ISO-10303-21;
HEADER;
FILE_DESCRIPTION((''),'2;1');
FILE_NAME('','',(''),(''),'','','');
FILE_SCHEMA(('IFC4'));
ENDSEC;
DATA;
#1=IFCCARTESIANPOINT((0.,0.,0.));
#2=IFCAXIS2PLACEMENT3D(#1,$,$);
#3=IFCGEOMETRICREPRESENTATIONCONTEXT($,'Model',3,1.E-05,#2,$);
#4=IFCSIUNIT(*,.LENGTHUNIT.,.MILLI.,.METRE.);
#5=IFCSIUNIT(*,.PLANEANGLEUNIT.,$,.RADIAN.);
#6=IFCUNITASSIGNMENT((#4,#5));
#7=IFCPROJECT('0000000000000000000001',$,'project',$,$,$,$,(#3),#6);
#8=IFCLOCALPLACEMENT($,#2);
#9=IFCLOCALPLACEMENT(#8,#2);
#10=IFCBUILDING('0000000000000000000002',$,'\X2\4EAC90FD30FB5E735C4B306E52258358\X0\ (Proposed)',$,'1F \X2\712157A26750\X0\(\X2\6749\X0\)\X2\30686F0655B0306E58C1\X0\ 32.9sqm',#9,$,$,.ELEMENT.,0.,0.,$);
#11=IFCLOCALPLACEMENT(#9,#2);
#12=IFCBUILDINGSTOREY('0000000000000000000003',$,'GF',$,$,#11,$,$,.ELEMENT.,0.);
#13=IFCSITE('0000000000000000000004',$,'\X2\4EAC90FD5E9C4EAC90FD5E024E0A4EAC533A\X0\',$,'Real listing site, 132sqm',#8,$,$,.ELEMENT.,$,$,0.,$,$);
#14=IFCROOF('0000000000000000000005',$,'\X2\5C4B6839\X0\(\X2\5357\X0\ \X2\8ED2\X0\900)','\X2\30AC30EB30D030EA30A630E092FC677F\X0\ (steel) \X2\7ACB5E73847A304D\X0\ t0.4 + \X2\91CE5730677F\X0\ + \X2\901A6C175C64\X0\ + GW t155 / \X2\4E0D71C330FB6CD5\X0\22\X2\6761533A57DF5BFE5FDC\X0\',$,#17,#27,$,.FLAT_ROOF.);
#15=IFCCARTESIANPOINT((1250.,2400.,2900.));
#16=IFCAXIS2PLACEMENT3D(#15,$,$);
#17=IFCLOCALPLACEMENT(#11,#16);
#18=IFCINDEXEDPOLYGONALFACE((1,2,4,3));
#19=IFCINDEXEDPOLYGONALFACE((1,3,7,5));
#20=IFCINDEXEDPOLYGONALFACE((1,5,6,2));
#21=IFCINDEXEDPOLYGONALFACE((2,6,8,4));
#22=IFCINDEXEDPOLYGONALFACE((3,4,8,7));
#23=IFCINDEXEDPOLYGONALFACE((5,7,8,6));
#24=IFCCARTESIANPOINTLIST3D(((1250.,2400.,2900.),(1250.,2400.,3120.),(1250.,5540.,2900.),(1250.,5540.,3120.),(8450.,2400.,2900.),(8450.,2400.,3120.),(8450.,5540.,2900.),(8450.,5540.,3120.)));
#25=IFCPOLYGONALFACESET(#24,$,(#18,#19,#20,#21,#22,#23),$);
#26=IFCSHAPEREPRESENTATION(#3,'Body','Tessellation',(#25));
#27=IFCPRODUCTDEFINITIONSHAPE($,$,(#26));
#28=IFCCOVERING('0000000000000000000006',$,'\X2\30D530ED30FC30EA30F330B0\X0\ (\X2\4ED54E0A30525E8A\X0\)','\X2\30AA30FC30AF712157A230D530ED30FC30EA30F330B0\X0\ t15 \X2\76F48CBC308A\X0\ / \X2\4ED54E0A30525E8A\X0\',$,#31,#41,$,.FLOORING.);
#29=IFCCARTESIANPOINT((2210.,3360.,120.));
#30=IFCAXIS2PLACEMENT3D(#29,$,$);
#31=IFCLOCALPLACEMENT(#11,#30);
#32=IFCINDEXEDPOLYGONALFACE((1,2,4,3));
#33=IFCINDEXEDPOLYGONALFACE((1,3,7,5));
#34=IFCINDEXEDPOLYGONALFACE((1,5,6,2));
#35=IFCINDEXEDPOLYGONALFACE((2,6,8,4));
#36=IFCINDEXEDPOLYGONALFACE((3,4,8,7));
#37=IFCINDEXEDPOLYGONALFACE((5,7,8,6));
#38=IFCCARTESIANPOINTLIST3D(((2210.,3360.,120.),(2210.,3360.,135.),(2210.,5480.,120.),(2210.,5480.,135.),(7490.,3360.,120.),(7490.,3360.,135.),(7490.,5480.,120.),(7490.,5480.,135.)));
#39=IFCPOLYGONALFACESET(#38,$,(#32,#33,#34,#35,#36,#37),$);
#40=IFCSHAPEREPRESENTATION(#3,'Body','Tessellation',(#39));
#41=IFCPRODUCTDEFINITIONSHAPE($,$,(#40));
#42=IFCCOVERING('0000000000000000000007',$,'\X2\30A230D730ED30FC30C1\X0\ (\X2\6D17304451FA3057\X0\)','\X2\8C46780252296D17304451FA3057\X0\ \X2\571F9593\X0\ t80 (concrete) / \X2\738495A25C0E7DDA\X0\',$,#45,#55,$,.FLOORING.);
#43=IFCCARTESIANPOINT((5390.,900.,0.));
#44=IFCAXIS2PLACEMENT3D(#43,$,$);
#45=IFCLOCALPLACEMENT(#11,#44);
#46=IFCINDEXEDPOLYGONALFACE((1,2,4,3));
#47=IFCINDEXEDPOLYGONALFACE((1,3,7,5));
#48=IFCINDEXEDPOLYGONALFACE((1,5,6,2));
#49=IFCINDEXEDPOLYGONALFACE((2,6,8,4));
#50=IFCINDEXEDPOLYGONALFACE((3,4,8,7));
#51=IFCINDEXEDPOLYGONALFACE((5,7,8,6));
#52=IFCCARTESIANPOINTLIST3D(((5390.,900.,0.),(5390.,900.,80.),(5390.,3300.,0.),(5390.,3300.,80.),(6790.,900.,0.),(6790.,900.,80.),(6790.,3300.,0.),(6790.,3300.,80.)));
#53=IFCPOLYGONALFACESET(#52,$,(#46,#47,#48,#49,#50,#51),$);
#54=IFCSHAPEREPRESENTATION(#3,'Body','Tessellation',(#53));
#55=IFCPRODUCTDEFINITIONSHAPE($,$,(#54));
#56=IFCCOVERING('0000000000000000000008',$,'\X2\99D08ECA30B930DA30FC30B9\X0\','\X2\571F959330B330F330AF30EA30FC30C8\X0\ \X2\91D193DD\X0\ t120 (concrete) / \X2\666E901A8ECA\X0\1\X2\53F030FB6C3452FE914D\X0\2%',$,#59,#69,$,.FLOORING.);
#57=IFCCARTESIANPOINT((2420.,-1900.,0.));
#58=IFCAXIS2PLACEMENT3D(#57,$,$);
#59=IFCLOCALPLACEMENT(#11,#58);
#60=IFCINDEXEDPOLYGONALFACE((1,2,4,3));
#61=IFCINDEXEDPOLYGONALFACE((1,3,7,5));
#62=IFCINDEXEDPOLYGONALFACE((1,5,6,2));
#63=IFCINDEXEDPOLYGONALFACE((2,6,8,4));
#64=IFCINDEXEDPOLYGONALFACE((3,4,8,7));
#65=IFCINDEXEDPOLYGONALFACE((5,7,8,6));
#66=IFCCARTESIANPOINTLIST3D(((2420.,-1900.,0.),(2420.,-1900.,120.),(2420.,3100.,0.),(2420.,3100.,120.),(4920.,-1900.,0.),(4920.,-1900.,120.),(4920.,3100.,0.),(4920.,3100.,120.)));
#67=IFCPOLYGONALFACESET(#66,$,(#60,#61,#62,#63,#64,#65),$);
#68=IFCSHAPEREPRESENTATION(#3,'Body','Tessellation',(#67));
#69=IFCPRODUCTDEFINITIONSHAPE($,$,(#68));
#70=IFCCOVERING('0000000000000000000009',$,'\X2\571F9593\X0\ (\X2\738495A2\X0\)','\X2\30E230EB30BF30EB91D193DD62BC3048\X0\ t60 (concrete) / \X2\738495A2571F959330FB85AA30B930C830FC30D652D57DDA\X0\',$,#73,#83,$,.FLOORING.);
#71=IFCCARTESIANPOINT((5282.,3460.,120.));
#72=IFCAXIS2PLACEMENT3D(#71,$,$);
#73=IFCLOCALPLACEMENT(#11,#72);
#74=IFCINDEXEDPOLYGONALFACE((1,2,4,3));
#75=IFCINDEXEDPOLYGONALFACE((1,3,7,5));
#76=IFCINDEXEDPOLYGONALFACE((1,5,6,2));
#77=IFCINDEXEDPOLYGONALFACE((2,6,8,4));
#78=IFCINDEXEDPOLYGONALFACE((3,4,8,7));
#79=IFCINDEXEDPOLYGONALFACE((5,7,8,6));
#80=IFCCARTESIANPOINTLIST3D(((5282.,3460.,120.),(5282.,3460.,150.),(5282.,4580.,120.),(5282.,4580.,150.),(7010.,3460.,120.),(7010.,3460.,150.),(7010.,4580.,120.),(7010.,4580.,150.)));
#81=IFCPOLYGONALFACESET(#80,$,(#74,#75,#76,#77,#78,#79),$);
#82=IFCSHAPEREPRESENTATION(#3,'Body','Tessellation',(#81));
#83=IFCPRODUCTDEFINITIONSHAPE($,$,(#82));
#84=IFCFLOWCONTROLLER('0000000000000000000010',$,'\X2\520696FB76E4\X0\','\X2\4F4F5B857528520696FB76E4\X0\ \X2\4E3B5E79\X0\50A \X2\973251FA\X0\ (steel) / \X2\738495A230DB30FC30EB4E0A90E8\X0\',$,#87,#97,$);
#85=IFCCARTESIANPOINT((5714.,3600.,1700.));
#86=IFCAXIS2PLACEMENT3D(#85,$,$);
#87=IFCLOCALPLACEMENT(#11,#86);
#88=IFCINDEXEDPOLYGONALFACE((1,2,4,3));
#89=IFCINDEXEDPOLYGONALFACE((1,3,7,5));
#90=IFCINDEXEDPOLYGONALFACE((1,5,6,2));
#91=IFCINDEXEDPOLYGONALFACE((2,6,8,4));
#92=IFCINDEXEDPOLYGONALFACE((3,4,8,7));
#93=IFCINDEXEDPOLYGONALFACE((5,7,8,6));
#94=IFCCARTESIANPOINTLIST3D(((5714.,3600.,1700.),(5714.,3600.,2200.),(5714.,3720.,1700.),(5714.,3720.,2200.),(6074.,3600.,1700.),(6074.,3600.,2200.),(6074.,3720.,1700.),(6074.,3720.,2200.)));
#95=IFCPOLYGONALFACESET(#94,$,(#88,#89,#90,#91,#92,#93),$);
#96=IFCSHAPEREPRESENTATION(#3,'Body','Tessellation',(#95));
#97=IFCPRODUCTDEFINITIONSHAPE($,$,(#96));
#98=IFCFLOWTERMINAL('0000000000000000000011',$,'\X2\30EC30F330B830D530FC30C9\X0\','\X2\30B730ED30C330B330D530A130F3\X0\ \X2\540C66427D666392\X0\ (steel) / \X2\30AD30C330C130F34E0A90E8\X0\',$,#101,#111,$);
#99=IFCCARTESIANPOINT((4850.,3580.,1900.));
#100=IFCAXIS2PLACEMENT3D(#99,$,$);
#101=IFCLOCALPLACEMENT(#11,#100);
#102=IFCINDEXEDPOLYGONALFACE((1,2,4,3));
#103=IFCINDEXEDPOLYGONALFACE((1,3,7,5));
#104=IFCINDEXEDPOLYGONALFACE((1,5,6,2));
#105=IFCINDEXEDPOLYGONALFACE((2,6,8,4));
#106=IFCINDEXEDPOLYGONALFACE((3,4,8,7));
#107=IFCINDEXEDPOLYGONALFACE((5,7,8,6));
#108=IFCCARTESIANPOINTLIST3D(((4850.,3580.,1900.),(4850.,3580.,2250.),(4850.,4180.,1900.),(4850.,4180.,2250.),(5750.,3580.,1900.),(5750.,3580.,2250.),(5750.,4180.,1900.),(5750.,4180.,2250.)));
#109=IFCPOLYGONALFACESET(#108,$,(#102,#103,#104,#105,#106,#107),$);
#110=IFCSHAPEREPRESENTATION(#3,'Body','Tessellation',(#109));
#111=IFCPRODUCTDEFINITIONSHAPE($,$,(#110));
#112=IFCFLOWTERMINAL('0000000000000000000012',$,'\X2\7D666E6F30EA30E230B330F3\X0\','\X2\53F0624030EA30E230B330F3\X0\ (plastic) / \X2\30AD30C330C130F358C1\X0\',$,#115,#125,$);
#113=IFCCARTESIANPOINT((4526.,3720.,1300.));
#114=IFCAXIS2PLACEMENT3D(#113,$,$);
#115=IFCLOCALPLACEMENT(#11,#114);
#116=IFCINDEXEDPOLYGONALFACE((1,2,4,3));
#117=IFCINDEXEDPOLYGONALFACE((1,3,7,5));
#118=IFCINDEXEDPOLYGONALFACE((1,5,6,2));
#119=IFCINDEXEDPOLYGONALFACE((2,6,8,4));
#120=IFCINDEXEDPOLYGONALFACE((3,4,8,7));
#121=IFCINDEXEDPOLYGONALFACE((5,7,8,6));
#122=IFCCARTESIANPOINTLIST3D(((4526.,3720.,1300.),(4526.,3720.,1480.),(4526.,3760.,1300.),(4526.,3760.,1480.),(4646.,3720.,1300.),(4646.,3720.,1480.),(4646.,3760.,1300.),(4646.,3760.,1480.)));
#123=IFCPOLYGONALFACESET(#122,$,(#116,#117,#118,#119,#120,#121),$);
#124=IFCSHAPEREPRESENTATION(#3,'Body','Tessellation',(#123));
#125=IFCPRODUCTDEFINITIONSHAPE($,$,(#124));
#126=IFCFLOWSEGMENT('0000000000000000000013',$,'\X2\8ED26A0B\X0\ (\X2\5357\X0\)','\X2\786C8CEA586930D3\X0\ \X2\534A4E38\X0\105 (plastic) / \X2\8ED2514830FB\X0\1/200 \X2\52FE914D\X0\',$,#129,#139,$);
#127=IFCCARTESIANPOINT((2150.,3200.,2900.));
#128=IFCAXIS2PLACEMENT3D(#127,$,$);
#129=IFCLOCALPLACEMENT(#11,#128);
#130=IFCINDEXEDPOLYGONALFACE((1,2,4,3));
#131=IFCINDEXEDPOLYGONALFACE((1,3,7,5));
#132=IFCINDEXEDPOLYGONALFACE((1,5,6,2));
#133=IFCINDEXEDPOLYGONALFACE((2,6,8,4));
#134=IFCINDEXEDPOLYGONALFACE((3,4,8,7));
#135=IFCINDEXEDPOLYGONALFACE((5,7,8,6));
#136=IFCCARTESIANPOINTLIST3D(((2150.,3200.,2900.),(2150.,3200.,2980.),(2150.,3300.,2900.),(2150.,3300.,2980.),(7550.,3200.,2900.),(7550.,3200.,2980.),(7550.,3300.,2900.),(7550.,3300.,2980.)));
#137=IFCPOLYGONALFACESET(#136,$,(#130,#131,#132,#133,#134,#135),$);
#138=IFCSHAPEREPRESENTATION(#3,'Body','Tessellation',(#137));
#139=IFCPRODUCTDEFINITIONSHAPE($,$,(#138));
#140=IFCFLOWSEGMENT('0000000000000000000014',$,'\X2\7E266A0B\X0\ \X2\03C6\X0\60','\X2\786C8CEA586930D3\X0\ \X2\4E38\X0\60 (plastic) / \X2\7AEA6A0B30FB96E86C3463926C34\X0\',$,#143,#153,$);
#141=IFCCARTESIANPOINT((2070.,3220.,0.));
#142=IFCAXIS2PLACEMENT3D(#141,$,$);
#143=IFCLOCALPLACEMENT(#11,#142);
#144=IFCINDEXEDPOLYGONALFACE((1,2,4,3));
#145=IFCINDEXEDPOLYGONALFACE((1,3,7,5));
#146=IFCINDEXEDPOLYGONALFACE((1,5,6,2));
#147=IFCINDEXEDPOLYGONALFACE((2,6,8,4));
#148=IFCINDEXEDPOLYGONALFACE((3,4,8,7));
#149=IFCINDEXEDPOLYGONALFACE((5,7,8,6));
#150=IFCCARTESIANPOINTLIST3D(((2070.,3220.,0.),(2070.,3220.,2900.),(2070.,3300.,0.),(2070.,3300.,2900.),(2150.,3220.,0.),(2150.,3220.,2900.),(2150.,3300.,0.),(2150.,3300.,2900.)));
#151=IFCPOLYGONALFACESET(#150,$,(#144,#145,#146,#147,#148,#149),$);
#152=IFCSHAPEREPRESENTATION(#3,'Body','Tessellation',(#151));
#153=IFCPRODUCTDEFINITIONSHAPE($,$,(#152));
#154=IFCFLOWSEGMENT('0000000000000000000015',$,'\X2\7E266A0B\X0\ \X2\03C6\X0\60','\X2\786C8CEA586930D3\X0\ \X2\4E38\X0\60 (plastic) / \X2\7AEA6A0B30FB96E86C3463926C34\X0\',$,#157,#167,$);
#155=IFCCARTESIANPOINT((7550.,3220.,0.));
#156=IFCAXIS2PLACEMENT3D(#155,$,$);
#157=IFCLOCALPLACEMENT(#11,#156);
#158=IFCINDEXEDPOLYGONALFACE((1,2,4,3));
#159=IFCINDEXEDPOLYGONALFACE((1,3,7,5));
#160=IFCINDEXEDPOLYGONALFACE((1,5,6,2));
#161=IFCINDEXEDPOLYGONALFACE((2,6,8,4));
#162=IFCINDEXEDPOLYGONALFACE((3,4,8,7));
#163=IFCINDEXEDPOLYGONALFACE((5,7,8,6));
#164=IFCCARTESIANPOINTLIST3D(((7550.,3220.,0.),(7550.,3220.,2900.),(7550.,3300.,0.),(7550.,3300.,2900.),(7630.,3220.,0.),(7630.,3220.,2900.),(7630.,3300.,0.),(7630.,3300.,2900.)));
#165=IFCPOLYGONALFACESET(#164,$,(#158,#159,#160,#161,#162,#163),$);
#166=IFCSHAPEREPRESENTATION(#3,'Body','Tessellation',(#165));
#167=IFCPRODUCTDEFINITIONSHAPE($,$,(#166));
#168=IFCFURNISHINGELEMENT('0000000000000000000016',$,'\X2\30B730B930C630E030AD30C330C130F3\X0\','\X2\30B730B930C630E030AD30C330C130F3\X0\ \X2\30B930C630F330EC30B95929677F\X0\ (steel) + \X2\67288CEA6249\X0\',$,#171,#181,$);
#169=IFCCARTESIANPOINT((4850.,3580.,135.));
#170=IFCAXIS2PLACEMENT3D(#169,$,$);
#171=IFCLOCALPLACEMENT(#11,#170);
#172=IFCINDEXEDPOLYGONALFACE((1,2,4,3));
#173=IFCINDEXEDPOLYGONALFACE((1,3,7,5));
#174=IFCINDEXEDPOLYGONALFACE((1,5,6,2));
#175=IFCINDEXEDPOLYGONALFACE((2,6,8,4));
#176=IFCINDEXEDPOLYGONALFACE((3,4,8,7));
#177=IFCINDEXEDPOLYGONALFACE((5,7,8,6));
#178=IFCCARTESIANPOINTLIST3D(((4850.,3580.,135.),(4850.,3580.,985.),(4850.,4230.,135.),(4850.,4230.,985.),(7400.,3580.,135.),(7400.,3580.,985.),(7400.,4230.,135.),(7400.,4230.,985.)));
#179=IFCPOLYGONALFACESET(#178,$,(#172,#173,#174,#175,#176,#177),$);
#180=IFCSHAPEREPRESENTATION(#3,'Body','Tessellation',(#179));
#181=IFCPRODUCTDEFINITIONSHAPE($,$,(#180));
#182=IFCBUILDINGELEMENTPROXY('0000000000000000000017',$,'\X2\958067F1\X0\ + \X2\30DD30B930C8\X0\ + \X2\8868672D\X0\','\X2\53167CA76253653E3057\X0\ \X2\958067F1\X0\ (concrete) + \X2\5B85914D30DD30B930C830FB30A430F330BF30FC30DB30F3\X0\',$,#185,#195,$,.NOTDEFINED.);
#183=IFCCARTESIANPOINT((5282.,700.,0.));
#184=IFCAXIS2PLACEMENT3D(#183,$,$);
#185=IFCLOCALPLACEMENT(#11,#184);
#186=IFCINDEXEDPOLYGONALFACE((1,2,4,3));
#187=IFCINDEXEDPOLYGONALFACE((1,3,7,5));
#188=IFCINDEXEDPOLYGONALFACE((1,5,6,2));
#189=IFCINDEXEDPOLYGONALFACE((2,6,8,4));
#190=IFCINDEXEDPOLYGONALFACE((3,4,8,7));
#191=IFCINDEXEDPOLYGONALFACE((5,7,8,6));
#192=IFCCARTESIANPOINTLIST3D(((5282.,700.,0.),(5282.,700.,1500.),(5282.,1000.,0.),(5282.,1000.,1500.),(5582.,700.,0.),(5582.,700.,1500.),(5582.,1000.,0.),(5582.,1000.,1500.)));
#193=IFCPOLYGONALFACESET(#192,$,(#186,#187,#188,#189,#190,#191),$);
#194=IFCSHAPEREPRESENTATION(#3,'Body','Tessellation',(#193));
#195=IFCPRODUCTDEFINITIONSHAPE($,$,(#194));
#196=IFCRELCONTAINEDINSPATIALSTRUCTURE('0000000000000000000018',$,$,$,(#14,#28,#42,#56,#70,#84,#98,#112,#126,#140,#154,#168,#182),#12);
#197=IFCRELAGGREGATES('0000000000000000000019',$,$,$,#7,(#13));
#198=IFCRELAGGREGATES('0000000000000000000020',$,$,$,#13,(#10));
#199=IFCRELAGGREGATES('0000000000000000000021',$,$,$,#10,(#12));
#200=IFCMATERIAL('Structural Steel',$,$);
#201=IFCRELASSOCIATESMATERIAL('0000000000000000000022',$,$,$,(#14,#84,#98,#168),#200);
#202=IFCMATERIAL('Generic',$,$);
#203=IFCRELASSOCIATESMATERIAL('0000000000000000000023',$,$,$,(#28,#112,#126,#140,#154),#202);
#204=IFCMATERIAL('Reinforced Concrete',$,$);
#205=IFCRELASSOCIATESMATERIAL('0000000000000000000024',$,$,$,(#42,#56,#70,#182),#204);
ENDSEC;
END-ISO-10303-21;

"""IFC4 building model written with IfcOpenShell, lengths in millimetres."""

from ifc_helpers import new_model, si_unit, frame, frame_2d, origin, place, context, project, spatial, rectangle, extrude, material, element, save


model = new_model("IFC4")

# Units and contexts
model_context = context("Model", 3, precision=1e-05, world=origin())
ifc_project = project(units=[si_unit("LENGTHUNIT", "METRE", prefix="MILLI"), si_unit("PLANEANGLEUNIT", "RADIAN")], contexts=[model_context])

# Site, building, storey
site_placement = place(None, origin())
site = spatial("IfcSite", under=ifc_project, at=site_placement, Name="京都府京都市上京区", ObjectType="Real listing site, 132sqm", CompositionType="ELEMENT", RefElevation=0.0)
building_placement = place(site_placement, origin())
building = spatial("IfcBuilding", under=site, at=building_placement, Name="京都・平屋の別荘 (Proposed)", ObjectType="1F 無垢材(杉)と漆喰の壁 32.9sqm", CompositionType="ELEMENT", ElevationOfRefHeight=0.0, ElevationOfTerrain=0.0)
storey_placement = place(building_placement, origin())
storey = spatial("IfcBuildingStorey", under=building, at=storey_placement, Name="GF", CompositionType="ELEMENT", Elevation=0.0)

# Shared definitions
ifc_material_1 = material(Name="Reinforced Concrete")

# Roof
ifc_material_2 = material(Name="Structural Steel")
roof_placement = place(storey_placement, frame((1250.0, 2400.0, 2900.0)))
element("IfcRoof", 1, at=roof_placement, inside=storey, material=ifc_material_2, Name="屋根(南 軒900)", Description="ガルバリウム鋼板 (steel) 立平葺き t0.4 + 野地板 + 通気層 + GW t155 / 不燃・法22条区域対応", PredefinedType="FLAT_ROOF", context=model_context, shape_type="SweptSolid", body=[
    extrude(rectangle(XDim=7200.0, YDim=3140.0, at=frame_2d((3600.0, 1570.0))), frame((1250.0, 2400.0, 2900.0)), (0.0, 0.0, 1.0), 220.0),
])

# Coverings
ifc_material_3 = material(Name="Generic")
covering_1_placement = place(storey_placement, frame((2210.0, 3360.0, 120.0)))
element("IfcCovering", 2, at=covering_1_placement, inside=storey, material=ifc_material_3, Name="フローリング (仕上げ床)", Description="オーク無垢フローリング t15 直貼り / 仕上げ床", PredefinedType="FLOORING", context=model_context, shape_type="SweptSolid", body=[
    extrude(rectangle(XDim=5280.0, YDim=2120.0, at=frame_2d((2640.0, 1060.0))), frame((2210.0, 3360.0, 120.0)), (0.0, 0.0, 1.0), 15.0),
])
covering_2_placement = place(storey_placement, frame((5390.0, 900.0, 0.0)))
element("IfcCovering", 3, at=covering_2_placement, inside=storey, material=ifc_material_1, Name="アプローチ (洗い出し)", Description="豆砂利洗い出し 土間 t80 (concrete) / 玄関導線", PredefinedType="FLOORING", context=model_context, shape_type="SweptSolid", body=[
    extrude(rectangle(XDim=1400.0, YDim=2400.0, at=frame_2d((700.0, 1200.0))), frame((5390.0, 900.0, 0.0)), (0.0, 0.0, 1.0), 80.0),
])
covering_3_placement = place(storey_placement, frame((2420.0, -1900.0, 0.0)))
element("IfcCovering", 4, at=covering_3_placement, inside=storey, material=ifc_material_1, Name="駐車スペース", Description="土間コンクリート 金鏝 t120 (concrete) / 普通車1台・水勾配2%", PredefinedType="FLOORING", context=model_context, shape_type="SweptSolid", body=[
    extrude(rectangle(XDim=2500.0, YDim=5000.0, at=frame_2d((1250.0, 2500.0))), frame((2420.0, -1900.0, 0.0)), (0.0, 0.0, 1.0), 120.0),
])
covering_4_placement = place(storey_placement, frame((5282.0, 3460.0, 120.0)))
element("IfcCovering", 5, at=covering_4_placement, inside=storey, material=ifc_material_1, Name="土間 (玄関)", Description="モルタル金鏝押え t60 (concrete) / 玄関土間・薪ストーブ動線", PredefinedType="FLOORING", context=model_context, shape_type="SweptSolid", body=[
    extrude(rectangle(XDim=1728.0, YDim=1120.0, at=frame_2d((864.0, 560.0))), frame((5282.0, 3460.0, 120.0)), (0.0, 0.0, 1.0), 30.0),
])

# Flow controller
flow_controller_placement = place(storey_placement, frame((5714.0, 3600.0, 1700.0)))
element("IfcFlowController", 6, at=flow_controller_placement, inside=storey, material=ifc_material_2, Name="分電盤", Description="住宅用分電盤 主幹50A 露出 (steel) / 玄関ホール上部", context=model_context, shape_type="SweptSolid", body=[
    extrude(rectangle(XDim=360.0, YDim=120.0, at=frame_2d((180.0, 60.0))), frame((5714.0, 3600.0, 1700.0)), (0.0, 0.0, 1.0), 500.0),
])

# Flow terminals
flow_terminal_1_placement = place(storey_placement, frame((4850.0, 3580.0, 1900.0)))
element("IfcFlowTerminal", 7, at=flow_terminal_1_placement, inside=storey, material=ifc_material_2, Name="レンジフード", Description="シロッコファン 同時給排 (steel) / キッチン上部", context=model_context, shape_type="SweptSolid", body=[
    extrude(rectangle(XDim=900.0, YDim=600.0, at=frame_2d((450.0, 300.0))), frame((4850.0, 3580.0, 1900.0)), (0.0, 0.0, 1.0), 350.0),
])
flow_terminal_2_placement = place(storey_placement, frame((4526.0, 3720.0, 1300.0)))
element("IfcFlowTerminal", 8, at=flow_terminal_2_placement, inside=storey, material=ifc_material_3, Name="給湯リモコン", Description="台所リモコン (plastic) / キッチン壁", context=model_context, shape_type="SweptSolid", body=[
    extrude(rectangle(XDim=120.0, YDim=40.0, at=frame_2d((60.0, 20.0))), frame((4526.0, 3720.0, 1300.0)), (0.0, 0.0, 1.0), 180.0),
])

# Flow segments
flow_segment_1_placement = place(storey_placement, frame((2150.0, 3200.0, 2900.0)))
element("IfcFlowSegment", 9, at=flow_segment_1_placement, inside=storey, material=ifc_material_3, Name="軒樋 (南)", Description="硬質塩ビ 半丸105 (plastic) / 軒先・1/200 勾配", context=model_context, shape_type="SweptSolid", body=[
    extrude(rectangle(XDim=5400.0, YDim=100.0, at=frame_2d((2700.0, 50.0))), frame((2150.0, 3200.0, 2900.0)), (0.0, 0.0, 1.0), 80.0),
])
flow_segment_2_placement = place(storey_placement, frame((2070.0, 3220.0, 0.0)))
element("IfcFlowSegment", 10, at=flow_segment_2_placement, inside=storey, material=ifc_material_3, Name="縦樋 φ60", Description="硬質塩ビ 丸60 (plastic) / 竪樋・雨水排水", context=model_context, shape_type="SweptSolid", body=[
    extrude(rectangle(XDim=80.0, YDim=80.0, at=frame_2d((40.0, 40.0))), frame((2070.0, 3220.0, 0.0)), (0.0, 0.0, 1.0), 2900.0),
])
flow_segment_3_placement = place(storey_placement, frame((7550.0, 3220.0, 0.0)))
element("IfcFlowSegment", 11, at=flow_segment_3_placement, inside=storey, material=ifc_material_3, Name="縦樋 φ60", Description="硬質塩ビ 丸60 (plastic) / 竪樋・雨水排水", context=model_context, shape_type="SweptSolid", body=[
    extrude(rectangle(XDim=80.0, YDim=80.0, at=frame_2d((40.0, 40.0))), frame((7550.0, 3220.0, 0.0)), (0.0, 0.0, 1.0), 2900.0),
])

# Furnishing element
furnishing_placement = place(storey_placement, frame((4850.0, 3580.0, 135.0)))
element("IfcFurnishingElement", 12, at=furnishing_placement, inside=storey, material=ifc_material_2, Name="システムキッチン", Description="システムキッチン ステンレス天板 (steel) + 木質扉", context=model_context, shape_type="SweptSolid", body=[
    extrude(rectangle(XDim=2550.0, YDim=650.0, at=frame_2d((1275.0, 325.0))), frame((4850.0, 3580.0, 135.0)), (0.0, 0.0, 1.0), 850.0),
])

# Building element proxy
proxy_placement = place(storey_placement, frame((5282.0, 700.0, 0.0)))
element("IfcBuildingElementProxy", 13, at=proxy_placement, inside=storey, material=ifc_material_1, Name="門柱 + ポスト + 表札", Description="化粧打放し 門柱 (concrete) + 宅配ポスト・インターホン", PredefinedType="NOTDEFINED", context=model_context, shape_type="SweptSolid", body=[
    extrude(rectangle(XDim=300.0, YDim=300.0, at=frame_2d((150.0, 150.0))), frame((5282.0, 700.0, 0.0)), (0.0, 0.0, 1.0), 1500.0),
])

save(model, "model.ifc")
